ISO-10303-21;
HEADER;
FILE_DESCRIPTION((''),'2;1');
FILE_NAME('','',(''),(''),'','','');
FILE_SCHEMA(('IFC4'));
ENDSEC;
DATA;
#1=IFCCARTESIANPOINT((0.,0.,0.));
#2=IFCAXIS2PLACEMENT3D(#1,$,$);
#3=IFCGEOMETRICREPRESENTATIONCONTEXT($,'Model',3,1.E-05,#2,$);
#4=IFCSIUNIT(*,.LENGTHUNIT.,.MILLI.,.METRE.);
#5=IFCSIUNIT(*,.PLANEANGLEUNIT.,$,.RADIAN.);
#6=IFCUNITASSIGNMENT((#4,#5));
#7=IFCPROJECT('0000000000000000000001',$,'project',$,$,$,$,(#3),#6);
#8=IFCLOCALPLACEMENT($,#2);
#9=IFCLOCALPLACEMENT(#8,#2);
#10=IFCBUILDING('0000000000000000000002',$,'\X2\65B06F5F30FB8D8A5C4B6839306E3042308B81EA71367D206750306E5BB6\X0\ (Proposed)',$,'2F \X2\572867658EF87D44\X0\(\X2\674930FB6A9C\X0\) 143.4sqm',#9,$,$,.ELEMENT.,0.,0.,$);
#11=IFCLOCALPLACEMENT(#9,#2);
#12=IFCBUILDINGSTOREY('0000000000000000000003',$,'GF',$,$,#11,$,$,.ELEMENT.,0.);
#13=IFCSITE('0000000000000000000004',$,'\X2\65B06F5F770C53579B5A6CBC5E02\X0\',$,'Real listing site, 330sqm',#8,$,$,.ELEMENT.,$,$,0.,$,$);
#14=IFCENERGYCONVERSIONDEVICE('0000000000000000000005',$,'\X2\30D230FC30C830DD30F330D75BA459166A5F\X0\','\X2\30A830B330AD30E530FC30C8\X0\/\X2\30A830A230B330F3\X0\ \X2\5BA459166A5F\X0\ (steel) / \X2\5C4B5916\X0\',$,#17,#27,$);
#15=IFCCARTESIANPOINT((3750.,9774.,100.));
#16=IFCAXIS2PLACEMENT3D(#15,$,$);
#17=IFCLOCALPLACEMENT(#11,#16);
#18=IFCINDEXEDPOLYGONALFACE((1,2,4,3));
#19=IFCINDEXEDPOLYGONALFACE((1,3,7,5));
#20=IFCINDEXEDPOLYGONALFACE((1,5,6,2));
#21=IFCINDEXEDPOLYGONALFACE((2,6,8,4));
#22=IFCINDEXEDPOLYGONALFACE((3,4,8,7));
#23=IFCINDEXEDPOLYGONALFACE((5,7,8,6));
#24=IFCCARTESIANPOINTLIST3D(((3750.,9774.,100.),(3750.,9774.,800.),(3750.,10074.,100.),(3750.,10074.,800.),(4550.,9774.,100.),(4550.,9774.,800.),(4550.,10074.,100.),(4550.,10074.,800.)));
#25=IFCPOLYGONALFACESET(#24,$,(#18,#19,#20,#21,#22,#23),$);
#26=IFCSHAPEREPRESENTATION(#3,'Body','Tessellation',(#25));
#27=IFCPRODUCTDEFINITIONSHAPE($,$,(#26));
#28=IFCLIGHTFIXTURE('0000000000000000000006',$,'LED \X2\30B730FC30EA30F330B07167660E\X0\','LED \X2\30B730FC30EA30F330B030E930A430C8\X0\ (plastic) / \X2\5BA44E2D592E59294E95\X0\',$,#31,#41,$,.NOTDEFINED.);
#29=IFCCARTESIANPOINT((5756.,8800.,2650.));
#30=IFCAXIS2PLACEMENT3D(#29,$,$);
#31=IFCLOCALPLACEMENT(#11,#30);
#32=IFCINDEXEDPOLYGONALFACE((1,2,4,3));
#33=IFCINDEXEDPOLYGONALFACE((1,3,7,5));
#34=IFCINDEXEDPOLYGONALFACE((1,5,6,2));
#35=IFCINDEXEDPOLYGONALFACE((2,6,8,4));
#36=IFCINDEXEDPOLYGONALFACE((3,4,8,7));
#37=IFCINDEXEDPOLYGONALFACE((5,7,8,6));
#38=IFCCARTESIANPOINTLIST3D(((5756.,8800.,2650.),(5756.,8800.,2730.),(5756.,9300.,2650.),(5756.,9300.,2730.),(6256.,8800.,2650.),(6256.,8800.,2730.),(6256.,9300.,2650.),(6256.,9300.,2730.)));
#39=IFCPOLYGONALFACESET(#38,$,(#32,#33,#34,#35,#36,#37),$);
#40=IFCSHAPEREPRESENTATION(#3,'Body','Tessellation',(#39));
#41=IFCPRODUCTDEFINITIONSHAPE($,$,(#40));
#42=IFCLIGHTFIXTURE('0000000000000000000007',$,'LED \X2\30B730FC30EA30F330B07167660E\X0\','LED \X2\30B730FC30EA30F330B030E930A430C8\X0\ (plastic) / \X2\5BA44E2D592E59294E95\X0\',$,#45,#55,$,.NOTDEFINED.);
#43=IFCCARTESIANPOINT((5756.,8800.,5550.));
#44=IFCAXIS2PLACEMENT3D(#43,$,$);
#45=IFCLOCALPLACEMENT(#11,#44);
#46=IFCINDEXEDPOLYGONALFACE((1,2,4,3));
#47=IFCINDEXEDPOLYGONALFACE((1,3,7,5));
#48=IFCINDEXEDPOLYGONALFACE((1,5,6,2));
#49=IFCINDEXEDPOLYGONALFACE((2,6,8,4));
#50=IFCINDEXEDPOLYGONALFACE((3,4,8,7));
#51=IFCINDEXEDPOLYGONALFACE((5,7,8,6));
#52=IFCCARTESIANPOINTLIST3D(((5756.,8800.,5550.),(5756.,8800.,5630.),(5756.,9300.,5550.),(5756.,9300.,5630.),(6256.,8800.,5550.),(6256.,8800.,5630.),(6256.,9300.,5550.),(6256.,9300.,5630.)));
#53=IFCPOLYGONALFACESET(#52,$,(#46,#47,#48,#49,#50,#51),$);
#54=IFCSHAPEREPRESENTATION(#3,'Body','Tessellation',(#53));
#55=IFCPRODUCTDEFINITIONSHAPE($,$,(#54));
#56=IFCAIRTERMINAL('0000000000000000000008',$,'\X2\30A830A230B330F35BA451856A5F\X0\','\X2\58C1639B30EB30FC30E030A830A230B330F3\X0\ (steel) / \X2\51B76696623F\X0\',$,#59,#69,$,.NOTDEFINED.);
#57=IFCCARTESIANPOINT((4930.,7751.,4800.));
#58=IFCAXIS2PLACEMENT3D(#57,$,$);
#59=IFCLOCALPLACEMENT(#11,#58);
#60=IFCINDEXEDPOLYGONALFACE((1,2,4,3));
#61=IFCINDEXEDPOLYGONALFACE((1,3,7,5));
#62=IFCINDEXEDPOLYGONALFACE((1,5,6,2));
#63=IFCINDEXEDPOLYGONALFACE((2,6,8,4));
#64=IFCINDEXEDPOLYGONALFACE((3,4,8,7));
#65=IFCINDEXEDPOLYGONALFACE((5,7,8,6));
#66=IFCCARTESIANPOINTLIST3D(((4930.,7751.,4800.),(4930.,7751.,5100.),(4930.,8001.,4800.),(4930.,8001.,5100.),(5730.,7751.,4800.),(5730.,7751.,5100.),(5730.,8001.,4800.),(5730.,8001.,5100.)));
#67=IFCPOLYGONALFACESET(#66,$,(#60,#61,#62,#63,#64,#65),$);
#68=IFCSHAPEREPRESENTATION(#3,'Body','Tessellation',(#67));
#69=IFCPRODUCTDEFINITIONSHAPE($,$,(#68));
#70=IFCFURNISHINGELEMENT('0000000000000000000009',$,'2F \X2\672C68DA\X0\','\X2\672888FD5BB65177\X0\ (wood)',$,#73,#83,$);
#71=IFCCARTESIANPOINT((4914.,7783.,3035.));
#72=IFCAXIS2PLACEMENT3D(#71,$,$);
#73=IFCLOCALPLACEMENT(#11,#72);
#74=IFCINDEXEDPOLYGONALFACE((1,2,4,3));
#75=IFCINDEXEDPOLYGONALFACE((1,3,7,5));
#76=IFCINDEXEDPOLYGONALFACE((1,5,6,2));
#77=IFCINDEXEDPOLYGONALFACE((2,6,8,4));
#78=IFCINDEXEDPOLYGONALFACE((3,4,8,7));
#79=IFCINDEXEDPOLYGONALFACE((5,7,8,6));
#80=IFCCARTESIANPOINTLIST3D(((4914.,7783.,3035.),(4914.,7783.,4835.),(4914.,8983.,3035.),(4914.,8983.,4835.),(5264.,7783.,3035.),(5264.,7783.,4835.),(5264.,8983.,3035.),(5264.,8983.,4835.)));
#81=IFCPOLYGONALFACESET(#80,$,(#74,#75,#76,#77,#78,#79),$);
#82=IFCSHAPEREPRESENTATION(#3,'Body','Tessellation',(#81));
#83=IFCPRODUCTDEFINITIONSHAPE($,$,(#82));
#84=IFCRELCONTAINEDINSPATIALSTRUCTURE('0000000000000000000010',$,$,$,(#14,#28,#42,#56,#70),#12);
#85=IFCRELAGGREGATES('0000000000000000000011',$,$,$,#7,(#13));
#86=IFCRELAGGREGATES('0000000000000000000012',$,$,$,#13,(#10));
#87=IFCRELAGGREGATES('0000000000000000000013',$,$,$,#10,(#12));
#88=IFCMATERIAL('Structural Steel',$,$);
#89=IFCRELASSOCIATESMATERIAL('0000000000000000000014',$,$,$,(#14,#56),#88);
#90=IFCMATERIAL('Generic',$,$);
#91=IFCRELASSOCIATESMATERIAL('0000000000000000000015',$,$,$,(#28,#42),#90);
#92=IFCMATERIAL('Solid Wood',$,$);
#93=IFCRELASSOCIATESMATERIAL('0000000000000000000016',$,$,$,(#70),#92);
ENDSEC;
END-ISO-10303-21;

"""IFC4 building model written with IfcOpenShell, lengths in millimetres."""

from ifc_helpers import new_model, si_unit, frame, frame_2d, origin, place, context, project, spatial, rectangle, extrude, material, element, save


model = new_model("IFC4")

# Units and contexts
model_context = context("Model", 3, precision=1e-05, world=origin())
ifc_project = project(units=[si_unit("LENGTHUNIT", "METRE", prefix="MILLI"), si_unit("PLANEANGLEUNIT", "RADIAN")], contexts=[model_context])

# Site, building, storey
site_placement = place(None, origin())
site = spatial("IfcSite", under=ifc_project, at=site_placement, Name="新潟県南魚沼市", ObjectType="Real listing site, 330sqm", CompositionType="ELEMENT", RefElevation=0.0)
building_placement = place(site_placement, origin())
building = spatial("IfcBuilding", under=site, at=building_placement, Name="新潟・越屋根のある自然素材の家 (Proposed)", ObjectType="2F 在来軸組(杉・檜) 143.4sqm", CompositionType="ELEMENT", ElevationOfRefHeight=0.0, ElevationOfTerrain=0.0)
storey_placement = place(building_placement, origin())
storey = spatial("IfcBuildingStorey", under=building, at=storey_placement, Name="GF", CompositionType="ELEMENT", Elevation=0.0)

# Shared definitions
ifc_material_1 = material(Name="Solid Wood")

# Shared definitions
ifc_material_2 = material(Name="Structural Steel")

# Shared definitions
ifc_material_3 = material(Name="Generic")

# Energy conversion device
energy_conversion_device_placement = place(storey_placement, frame((3750.0, 9774.0, 100.0)))
element("IfcEnergyConversionDevice", 1, at=energy_conversion_device_placement, inside=storey, material=ifc_material_2, Name="ヒートポンプ室外機", Description="エコキュート/エアコン 室外機 (steel) / 屋外", context=model_context, shape_type="SweptSolid", body=[
    extrude(rectangle(XDim=800.0, YDim=300.0, at=frame_2d((400.0, 150.0))), frame((3750.0, 9774.0, 100.0)), (0.0, 0.0, 1.0), 700.0),
])

# Light fixtures
light_fixture_1_placement = place(storey_placement, frame((5756.0, 8800.0, 2650.0)))
element("IfcLightFixture", 2, at=light_fixture_1_placement, inside=storey, material=ifc_material_3, Name="LED シーリング照明", Description="LED シーリングライト (plastic) / 室中央天井", PredefinedType="NOTDEFINED", context=model_context, shape_type="SweptSolid", body=[
    extrude(rectangle(XDim=500.0, YDim=500.0, at=frame_2d((250.0, 250.0))), frame((5756.0, 8800.0, 2650.0)), (0.0, 0.0, 1.0), 80.0),
])
light_fixture_2_placement = place(storey_placement, frame((5756.0, 8800.0, 5550.0)))
element("IfcLightFixture", 3, at=light_fixture_2_placement, inside=storey, material=ifc_material_3, Name="LED シーリング照明", Description="LED シーリングライト (plastic) / 室中央天井", PredefinedType="NOTDEFINED", context=model_context, shape_type="SweptSolid", body=[
    extrude(rectangle(XDim=500.0, YDim=500.0, at=frame_2d((250.0, 250.0))), frame((5756.0, 8800.0, 5550.0)), (0.0, 0.0, 1.0), 80.0),
])

# Air terminal
air_terminal_placement = place(storey_placement, frame((4930.0, 7751.0, 4800.0)))
element("IfcAirTerminal", 4, at=air_terminal_placement, inside=storey, material=ifc_material_2, Name="エアコン室内機", Description="壁掛ルームエアコン (steel) / 冷暖房", PredefinedType="NOTDEFINED", context=model_context, shape_type="SweptSolid", body=[
    extrude(rectangle(XDim=800.0, YDim=250.0, at=frame_2d((400.0, 125.0))), frame((4930.0, 7751.0, 4800.0)), (0.0, 0.0, 1.0), 300.0),
])

# Furnishing element
furnishing_placement = place(storey_placement, frame((4914.0, 7783.0, 3035.0)))
element("IfcFurnishingElement", 5, at=furnishing_placement, inside=storey, material=ifc_material_1, Name="2F 本棚", Description="木製家具 (wood)", context=model_context, shape_type="SweptSolid", body=[
    extrude(rectangle(XDim=350.0, YDim=1200.0, at=frame_2d((175.0, 600.0))), frame((4914.0, 7783.0, 3035.0)), (0.0, 0.0, 1.0), 1800.0),
])

save(model, "model.ifc")
